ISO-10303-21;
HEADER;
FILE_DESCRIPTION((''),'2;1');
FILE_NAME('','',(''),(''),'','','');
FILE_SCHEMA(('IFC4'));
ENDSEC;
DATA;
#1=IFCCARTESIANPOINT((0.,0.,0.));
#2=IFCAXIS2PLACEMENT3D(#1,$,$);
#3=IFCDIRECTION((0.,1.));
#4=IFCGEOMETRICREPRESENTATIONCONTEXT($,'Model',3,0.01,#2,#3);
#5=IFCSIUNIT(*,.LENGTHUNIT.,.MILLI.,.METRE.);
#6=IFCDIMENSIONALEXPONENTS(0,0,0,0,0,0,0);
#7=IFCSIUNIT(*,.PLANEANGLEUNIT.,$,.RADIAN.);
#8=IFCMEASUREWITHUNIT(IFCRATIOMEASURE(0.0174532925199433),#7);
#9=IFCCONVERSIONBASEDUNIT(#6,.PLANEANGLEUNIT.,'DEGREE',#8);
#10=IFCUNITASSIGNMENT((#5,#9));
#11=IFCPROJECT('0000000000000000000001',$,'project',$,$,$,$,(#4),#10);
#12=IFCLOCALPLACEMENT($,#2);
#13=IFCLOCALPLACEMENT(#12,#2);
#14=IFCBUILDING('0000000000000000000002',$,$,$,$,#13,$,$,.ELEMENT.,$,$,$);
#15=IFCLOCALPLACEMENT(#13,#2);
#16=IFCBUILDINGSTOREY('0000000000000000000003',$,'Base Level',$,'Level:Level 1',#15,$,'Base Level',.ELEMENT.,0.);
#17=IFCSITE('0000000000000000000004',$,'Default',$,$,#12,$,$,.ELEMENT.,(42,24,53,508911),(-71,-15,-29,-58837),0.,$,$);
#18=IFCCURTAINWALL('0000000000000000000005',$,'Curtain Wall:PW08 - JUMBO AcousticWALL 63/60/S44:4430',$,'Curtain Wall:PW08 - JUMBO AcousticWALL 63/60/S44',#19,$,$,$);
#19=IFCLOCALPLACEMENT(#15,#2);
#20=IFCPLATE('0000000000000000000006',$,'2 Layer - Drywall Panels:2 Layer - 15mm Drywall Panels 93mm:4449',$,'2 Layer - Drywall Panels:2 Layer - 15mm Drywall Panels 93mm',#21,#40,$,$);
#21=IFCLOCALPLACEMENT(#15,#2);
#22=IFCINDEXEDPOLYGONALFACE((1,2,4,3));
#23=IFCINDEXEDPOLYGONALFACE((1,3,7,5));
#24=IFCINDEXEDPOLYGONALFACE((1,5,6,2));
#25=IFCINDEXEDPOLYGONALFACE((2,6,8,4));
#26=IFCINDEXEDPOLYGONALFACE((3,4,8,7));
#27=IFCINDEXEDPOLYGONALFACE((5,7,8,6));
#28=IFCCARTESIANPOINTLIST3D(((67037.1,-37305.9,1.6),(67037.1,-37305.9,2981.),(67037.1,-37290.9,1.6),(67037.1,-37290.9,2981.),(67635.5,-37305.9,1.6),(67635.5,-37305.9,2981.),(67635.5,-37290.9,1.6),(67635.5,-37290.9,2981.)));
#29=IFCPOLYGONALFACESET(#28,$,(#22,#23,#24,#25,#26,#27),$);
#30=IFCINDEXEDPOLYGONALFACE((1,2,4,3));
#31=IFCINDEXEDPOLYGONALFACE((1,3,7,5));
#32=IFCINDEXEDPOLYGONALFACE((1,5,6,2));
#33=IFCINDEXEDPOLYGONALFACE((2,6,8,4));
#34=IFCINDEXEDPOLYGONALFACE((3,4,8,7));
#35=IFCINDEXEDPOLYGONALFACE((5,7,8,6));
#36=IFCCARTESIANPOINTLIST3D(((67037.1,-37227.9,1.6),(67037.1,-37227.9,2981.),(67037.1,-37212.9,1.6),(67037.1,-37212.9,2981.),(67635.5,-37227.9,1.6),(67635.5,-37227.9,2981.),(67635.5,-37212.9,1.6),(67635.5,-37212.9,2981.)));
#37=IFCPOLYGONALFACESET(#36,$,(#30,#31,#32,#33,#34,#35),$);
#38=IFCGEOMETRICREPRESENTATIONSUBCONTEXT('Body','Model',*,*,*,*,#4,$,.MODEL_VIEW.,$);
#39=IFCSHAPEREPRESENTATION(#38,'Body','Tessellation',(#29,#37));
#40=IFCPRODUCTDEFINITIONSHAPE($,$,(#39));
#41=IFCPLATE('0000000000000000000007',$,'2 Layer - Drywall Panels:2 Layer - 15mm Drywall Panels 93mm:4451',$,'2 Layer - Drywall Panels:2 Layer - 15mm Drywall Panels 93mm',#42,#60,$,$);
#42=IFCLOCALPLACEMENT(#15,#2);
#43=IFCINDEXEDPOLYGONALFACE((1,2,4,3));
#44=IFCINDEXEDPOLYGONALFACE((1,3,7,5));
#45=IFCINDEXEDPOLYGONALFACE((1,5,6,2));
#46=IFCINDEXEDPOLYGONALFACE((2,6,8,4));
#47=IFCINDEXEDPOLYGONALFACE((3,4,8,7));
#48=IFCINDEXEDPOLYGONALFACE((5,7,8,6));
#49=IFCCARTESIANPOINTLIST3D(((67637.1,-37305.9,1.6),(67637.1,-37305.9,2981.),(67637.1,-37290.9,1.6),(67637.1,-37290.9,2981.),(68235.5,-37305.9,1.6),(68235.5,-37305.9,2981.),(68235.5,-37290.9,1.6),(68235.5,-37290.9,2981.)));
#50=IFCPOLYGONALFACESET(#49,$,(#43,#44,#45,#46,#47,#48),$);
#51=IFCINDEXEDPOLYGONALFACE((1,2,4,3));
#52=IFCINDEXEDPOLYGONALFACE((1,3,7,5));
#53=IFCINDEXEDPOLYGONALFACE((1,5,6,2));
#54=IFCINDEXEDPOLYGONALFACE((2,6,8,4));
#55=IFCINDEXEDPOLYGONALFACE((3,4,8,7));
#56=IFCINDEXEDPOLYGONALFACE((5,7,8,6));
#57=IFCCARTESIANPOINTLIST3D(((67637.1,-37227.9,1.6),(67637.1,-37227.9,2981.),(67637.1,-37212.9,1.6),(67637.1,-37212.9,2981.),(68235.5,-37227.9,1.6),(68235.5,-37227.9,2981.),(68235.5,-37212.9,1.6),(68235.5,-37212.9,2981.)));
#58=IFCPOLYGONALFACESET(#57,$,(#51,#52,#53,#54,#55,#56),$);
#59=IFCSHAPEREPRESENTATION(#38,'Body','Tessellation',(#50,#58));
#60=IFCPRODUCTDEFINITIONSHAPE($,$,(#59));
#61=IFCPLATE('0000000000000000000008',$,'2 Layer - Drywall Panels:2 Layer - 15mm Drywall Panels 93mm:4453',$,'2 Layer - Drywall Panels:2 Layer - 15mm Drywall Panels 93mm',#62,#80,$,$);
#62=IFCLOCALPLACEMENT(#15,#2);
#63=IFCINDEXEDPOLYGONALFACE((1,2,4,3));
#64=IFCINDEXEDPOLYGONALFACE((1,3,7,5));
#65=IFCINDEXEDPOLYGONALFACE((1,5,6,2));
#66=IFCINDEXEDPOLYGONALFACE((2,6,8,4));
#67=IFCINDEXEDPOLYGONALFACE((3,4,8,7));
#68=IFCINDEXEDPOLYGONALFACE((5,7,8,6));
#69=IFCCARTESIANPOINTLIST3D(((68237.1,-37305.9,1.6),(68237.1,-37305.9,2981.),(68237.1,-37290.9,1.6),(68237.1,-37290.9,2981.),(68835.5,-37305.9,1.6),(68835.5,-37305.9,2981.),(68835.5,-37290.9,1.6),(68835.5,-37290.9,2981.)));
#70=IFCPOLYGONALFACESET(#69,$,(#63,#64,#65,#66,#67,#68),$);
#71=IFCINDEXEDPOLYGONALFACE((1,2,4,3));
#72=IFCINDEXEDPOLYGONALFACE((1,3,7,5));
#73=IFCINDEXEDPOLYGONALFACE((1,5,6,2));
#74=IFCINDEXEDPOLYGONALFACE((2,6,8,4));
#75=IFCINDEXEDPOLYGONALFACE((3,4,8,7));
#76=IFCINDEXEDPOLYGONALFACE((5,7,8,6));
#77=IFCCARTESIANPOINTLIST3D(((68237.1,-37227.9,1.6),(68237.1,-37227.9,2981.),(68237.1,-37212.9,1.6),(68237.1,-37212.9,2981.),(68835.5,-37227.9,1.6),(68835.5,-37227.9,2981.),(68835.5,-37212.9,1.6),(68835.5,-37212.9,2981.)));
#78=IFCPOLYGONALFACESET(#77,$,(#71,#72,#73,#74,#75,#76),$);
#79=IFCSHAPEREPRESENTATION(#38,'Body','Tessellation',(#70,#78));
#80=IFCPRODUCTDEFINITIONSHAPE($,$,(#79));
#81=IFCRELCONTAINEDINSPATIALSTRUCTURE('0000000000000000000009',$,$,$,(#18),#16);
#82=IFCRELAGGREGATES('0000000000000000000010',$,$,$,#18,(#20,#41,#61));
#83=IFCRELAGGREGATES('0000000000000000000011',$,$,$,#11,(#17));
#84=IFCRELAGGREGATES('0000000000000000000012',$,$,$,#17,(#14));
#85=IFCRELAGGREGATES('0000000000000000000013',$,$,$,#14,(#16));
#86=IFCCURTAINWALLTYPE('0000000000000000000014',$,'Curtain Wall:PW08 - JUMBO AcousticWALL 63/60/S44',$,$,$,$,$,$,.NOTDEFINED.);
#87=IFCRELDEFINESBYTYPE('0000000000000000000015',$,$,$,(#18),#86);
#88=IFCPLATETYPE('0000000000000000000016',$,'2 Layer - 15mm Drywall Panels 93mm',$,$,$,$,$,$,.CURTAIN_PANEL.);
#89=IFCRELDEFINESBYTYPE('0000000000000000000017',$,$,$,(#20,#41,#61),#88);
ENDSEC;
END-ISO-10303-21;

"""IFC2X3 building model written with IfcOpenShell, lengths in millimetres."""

from ifc_helpers import new_model, entity, si_unit, converted_unit, direction, frame, frame_2d, origin, place, context, subcontext, project, spatial, rectangle, extrude, source, transform, mapped, type_object, type_shapes, element, aggregate, save


model = new_model("IFC2X3")

# Units and contexts
model_context = context("Model", 3, precision=0.01, world=origin(), true_north=direction((0.0, 1.0)))
body_context = subcontext(model_context, "Body", "Model", "MODEL_VIEW")
ifc_project = project(units=[si_unit("LENGTHUNIT", "METRE", prefix="MILLI"), converted_unit("PLANEANGLEUNIT", "DEGREE", entity("IfcRatioMeasure", 0.0174532925199433), si_unit("PLANEANGLEUNIT", "RADIAN"), dimensions=[0, 0, 0, 0, 0, 0, 0])], contexts=[model_context])

# Site, building, storey
site_placement = place(None, origin())
site = spatial("IfcSite", under=ifc_project, at=site_placement, Name="Default", CompositionType="ELEMENT", RefLatitude=(42, 24, 53, 508911), RefLongitude=(-71, -15, -29, -58837), RefElevation=0.0)
building_placement = place(site_placement, origin())
building = spatial("IfcBuilding", under=site, at=building_placement, CompositionType="ELEMENT")
storey_placement = place(building_placement, origin())
storey = spatial("IfcBuildingStorey", under=building, at=storey_placement, Name="Base Level", ObjectType="Level:Level 1", LongName="Base Level", CompositionType="ELEMENT", Elevation=0.0)

# Curtain wall, plates
curtain_wall_type = type_object("IfcCurtainWallType", Name="Curtain Wall:PW08 - JUMBO AcousticWALL 63/60/S44", PredefinedType="NOTDEFINED")
curtain_wall_placement = place(building_placement, origin())
curtain_wall = element("IfcCurtainWall", 1, at=curtain_wall_placement, inside=storey, type_object=curtain_wall_type, Name="Curtain Wall:PW08 - JUMBO AcousticWALL 63/60/S44:4430", ObjectType="Curtain Wall:PW08 - JUMBO AcousticWALL 63/60/S44")
plate_type = type_object("IfcPlateType", Name="2 Layer - 15mm Drywall Panels 93mm", PredefinedType="CURTAIN_PANEL")
shared_shape_1 = source(origin(), body_context, "Body", "SweptSolid", [
    extrude(rectangle(XDim=598.4, YDim=15.0, at=frame_2d((0.0, 0.0), x_axis=(1.0, 0.0))), frame((0.0, -39.0, 0.0), z_axis=(0.0, 0.0, 1.0), x_axis=(-1.0, 0.0, 0.0)), (0.0, 0.0, 1.0), 2979.4),
    extrude(rectangle(XDim=15.0, YDim=598.4, at=frame_2d((0.0, 0.0), x_axis=(1.0, 0.0))), frame((0.0, 39.0, 0.0), z_axis=(0.0, 0.0, 1.0), x_axis=(0.0, 1.0, 0.0)), (0.0, 0.0, 1.0), 2979.4),
])
type_shapes(plate_type, [shared_shape_1])
plate_1_placement = place(curtain_wall_placement, frame((67336.3, -37259.4, 1.6)))
plate_1 = element("IfcPlate", 2, at=plate_1_placement, type_object=plate_type, Name="2 Layer - Drywall Panels:2 Layer - 15mm Drywall Panels 93mm:4449", ObjectType="2 Layer - Drywall Panels:2 Layer - 15mm Drywall Panels 93mm", context=body_context, shape_type="MappedRepresentation", body=[
    mapped(shared_shape_1, transform((0.0, 0.0, 0.0), scale=1.0)),
])
plate_2_placement = place(curtain_wall_placement, frame((67936.3, -37259.4, 1.6)))
plate_2 = element("IfcPlate", 3, at=plate_2_placement, type_object=plate_type, Name="2 Layer - Drywall Panels:2 Layer - 15mm Drywall Panels 93mm:4451", ObjectType="2 Layer - Drywall Panels:2 Layer - 15mm Drywall Panels 93mm", context=body_context, shape_type="MappedRepresentation", body=[
    mapped(shared_shape_1, transform((0.0, 0.0, 0.0), scale=1.0)),
])
plate_3_placement = place(curtain_wall_placement, frame((68536.3, -37259.4, 1.6)))
plate_3 = element("IfcPlate", 4, at=plate_3_placement, type_object=plate_type, Name="2 Layer - Drywall Panels:2 Layer - 15mm Drywall Panels 93mm:4453", ObjectType="2 Layer - Drywall Panels:2 Layer - 15mm Drywall Panels 93mm", context=body_context, shape_type="MappedRepresentation", body=[
    mapped(shared_shape_1, transform((0.0, 0.0, 0.0), scale=1.0)),
])
aggregate(curtain_wall, [plate_1, plate_2, plate_3])

save(model, "model.ifc")
